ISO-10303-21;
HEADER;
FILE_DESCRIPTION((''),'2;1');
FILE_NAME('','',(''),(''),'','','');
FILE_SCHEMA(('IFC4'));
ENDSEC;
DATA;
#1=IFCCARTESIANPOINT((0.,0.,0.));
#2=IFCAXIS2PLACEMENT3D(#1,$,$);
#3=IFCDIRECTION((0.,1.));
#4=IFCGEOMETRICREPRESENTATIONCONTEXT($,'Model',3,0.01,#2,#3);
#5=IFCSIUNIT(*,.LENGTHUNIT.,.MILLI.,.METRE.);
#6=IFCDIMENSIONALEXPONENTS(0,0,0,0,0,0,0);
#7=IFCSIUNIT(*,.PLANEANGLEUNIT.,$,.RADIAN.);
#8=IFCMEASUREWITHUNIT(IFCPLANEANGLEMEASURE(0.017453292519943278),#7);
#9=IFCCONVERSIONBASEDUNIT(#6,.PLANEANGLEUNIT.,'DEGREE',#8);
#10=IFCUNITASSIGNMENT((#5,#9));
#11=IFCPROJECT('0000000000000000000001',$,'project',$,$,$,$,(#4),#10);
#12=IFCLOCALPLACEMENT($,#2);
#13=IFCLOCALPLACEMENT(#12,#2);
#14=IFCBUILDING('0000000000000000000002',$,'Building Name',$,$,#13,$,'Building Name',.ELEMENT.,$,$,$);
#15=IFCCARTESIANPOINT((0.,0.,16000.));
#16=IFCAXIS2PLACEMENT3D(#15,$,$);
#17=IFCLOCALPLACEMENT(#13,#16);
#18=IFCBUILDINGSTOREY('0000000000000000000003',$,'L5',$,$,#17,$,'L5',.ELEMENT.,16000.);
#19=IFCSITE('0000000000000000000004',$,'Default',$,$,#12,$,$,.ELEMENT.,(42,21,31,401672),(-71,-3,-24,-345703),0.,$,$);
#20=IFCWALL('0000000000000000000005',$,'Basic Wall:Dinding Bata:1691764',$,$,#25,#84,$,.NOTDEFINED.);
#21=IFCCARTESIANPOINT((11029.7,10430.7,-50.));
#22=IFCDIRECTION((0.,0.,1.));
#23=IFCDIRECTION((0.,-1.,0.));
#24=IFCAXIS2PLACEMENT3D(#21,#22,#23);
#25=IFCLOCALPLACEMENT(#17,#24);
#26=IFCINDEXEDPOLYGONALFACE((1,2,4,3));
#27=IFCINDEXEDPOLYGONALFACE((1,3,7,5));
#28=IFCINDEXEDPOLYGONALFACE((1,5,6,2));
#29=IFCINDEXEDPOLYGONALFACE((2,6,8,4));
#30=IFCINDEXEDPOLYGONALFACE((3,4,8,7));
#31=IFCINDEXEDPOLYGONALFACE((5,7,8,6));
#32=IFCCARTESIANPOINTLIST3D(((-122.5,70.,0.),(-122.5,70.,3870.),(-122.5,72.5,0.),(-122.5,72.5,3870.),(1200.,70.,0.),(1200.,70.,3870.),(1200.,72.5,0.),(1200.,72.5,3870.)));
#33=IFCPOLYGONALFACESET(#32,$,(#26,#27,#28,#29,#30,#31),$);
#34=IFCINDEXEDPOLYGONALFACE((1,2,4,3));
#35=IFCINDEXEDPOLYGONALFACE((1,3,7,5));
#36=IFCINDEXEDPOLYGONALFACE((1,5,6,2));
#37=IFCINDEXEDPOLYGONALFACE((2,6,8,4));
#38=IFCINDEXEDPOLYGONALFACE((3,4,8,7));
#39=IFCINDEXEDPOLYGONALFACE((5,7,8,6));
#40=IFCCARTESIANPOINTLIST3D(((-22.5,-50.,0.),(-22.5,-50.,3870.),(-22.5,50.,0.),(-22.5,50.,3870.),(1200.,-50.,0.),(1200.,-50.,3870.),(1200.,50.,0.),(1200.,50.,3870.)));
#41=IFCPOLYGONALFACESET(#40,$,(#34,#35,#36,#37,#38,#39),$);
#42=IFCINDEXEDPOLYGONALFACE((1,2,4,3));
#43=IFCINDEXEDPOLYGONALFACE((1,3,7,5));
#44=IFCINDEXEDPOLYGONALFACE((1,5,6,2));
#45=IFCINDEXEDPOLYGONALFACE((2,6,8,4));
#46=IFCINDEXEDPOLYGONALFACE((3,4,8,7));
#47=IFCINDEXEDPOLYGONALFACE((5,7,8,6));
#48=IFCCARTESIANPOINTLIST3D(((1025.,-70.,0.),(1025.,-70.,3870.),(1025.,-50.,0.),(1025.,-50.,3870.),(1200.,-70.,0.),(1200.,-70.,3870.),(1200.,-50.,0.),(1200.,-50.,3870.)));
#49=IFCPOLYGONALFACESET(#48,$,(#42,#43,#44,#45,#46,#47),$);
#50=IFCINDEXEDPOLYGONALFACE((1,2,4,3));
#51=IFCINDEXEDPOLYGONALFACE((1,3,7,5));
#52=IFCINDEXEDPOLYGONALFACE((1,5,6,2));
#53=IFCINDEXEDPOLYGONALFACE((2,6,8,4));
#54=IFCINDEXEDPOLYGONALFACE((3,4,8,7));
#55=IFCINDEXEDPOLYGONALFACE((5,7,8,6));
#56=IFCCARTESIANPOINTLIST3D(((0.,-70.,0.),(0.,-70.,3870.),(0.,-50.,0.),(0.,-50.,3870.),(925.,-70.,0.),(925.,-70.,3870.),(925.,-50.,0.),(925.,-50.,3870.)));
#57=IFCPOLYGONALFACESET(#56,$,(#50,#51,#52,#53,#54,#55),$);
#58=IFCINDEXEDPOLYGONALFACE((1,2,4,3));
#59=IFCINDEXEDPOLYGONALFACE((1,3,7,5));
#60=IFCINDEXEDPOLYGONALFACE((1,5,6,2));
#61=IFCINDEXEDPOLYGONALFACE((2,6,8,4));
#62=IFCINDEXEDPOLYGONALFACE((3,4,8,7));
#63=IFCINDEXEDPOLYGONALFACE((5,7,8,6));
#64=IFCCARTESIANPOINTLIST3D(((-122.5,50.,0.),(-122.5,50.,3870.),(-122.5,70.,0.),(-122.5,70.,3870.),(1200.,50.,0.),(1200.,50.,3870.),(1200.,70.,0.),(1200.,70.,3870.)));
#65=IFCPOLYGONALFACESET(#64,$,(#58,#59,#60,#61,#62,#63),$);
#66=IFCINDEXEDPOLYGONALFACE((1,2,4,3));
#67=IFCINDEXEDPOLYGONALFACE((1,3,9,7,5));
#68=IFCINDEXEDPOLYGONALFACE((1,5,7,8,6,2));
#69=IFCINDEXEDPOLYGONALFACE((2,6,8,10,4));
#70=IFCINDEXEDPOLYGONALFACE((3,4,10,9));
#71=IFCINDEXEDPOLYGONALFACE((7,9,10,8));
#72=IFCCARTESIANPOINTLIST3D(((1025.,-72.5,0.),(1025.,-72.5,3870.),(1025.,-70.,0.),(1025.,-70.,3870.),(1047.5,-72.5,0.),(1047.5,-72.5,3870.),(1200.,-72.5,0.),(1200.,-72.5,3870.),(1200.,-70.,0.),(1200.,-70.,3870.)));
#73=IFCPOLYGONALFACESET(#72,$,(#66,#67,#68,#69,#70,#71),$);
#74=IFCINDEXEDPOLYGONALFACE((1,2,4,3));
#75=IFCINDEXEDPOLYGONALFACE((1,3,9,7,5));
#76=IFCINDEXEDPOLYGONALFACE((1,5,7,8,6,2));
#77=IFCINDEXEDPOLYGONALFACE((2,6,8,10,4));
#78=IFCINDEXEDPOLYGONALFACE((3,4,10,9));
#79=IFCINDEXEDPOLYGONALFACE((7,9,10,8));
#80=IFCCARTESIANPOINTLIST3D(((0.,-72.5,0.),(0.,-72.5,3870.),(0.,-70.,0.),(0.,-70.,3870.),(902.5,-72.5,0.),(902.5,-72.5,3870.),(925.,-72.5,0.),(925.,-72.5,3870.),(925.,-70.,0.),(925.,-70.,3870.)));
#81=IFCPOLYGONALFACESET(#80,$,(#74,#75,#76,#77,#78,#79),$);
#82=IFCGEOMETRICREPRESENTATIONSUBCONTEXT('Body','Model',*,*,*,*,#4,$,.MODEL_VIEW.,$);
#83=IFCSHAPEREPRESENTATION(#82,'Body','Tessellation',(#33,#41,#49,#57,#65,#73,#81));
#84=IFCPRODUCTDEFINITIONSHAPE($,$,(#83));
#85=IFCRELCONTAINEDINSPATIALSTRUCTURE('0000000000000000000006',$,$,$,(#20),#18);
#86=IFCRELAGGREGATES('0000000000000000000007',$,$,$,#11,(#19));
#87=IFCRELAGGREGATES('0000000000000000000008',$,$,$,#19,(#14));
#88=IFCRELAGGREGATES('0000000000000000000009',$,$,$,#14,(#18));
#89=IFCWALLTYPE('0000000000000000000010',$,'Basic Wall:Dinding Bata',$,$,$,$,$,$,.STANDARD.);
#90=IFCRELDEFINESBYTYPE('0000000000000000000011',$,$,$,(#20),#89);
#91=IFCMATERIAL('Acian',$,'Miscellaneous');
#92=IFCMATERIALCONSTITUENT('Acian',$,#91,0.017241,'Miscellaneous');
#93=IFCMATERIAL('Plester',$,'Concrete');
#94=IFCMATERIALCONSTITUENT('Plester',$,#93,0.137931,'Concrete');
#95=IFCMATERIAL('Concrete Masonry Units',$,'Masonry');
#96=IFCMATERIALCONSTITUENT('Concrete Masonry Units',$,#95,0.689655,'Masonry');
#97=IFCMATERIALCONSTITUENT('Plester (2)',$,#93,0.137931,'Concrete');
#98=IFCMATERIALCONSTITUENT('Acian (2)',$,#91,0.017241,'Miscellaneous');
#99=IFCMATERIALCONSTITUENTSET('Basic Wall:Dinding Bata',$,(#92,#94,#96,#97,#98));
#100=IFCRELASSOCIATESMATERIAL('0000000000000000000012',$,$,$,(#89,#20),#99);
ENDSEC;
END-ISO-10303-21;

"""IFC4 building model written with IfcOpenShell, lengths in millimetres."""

from ifc_helpers import new_model, entity, si_unit, converted_unit, direction, frame, origin, place, context, subcontext, project, spatial, indexed_curve, outline, extrude, material, constituent, constituent_set, type_object, element, save


model = new_model("IFC4")

# Units and contexts
model_context = context("Model", 3, precision=0.01, world=origin(), true_north=direction((0.0, 1.0)))
body_context = subcontext(model_context, "Body", "Model", "MODEL_VIEW")
ifc_project = project(units=[si_unit("LENGTHUNIT", "METRE", prefix="MILLI"), converted_unit("PLANEANGLEUNIT", "DEGREE", entity("IfcPlaneAngleMeasure", 0.017453292519943278), si_unit("PLANEANGLEUNIT", "RADIAN"), dimensions=[0, 0, 0, 0, 0, 0, 0])], contexts=[model_context])

# Site, building, storey
site_placement = place(None, origin())
site = spatial("IfcSite", under=ifc_project, at=site_placement, Name="Default", CompositionType="ELEMENT", RefLatitude=(42, 21, 31, 401672), RefLongitude=(-71, -3, -24, -345703), RefElevation=0.0)
building_placement = place(site_placement, origin())
building = spatial("IfcBuilding", under=site, at=building_placement, Name="Building Name", LongName="Building Name", CompositionType="ELEMENT")
storey_placement = place(building_placement, frame((0.0, 0.0, 16000.0)))
storey = spatial("IfcBuildingStorey", under=building, at=storey_placement, Name="L5", LongName="L5", CompositionType="ELEMENT", Elevation=16000.0)

# Wall
ifc_material_1 = material(Name="Acian", Category="Miscellaneous")
ifc_constituent_1 = constituent(ifc_material_1, Name="Acian", Category="Miscellaneous", fraction=0.017241)
ifc_material_2 = material(Name="Plester", Category="Concrete")
ifc_constituent_2 = constituent(ifc_material_2, Name="Plester", Category="Concrete", fraction=0.137931)
ifc_material_3 = material(Name="Concrete Masonry Units", Category="Masonry")
ifc_constituent_3 = constituent(ifc_material_3, Name="Concrete Masonry Units", Category="Masonry", fraction=0.689655)
ifc_constituent_4 = constituent(ifc_material_2, Name="Plester (2)", Category="Concrete", fraction=0.137931)
ifc_constituent_5 = constituent(ifc_material_1, Name="Acian (2)", Category="Miscellaneous", fraction=0.017241)
ifc_constituent_set = constituent_set(constituents=[ifc_constituent_1, ifc_constituent_2, ifc_constituent_3, ifc_constituent_4, ifc_constituent_5], Name="Basic Wall:Dinding Bata")
wall_type = type_object("IfcWallType", Name="Basic Wall:Dinding Bata", PredefinedType="STANDARD", material=ifc_constituent_set)
wall_1_placement = place(storey_placement, frame((11029.7, 10430.7, -50.0), z_axis=(0.0, 0.0, 1.0), x_axis=(0.0, -1.0, 0.0)))
element("IfcWall", 1, at=wall_1_placement, inside=storey, type_object=wall_type, material=ifc_constituent_set, Name="Basic Wall:Dinding Bata:1691764", PredefinedType="NOTDEFINED", context=body_context, shape_type="SweptSolid", body=[
    extrude(outline(indexed_curve([(-1.3, -661.2), (1.2, -661.2), (1.3, 661.2), (-1.2, 661.2), (-1.3, -661.2)], self_intersect=False)), frame((538.7, 71.2, 0.0), z_axis=(0.0, 0.0, 1.0), x_axis=(0.0, -1.0, 0.0)), (0.0, 0.0, 1.0), 3870.0),
    extrude(outline(indexed_curve([(-611.2, -50.0), (611.2, -50.0), (611.2, 50.0), (-611.2, 50.0), (-611.2, -50.0)], self_intersect=False)), frame((588.7, 0.0, 0.0)), (0.0, 0.0, 1.0), 3870.0),
    extrude(outline(indexed_curve([(-87.5, -10.0), (87.5, -10.0), (87.5, 10.0), (-87.5, 10.0), (-87.5, -10.0)], self_intersect=False)), frame((1112.5, -60.0, 0.0), z_axis=(0.0, 0.0, 1.0), x_axis=(-1.0, 0.0, 0.0)), (0.0, 0.0, 1.0), 3870.0),
    extrude(outline(indexed_curve([(-462.5, -10.0), (462.5, -10.0), (462.5, 10.0), (-462.5, 10.0), (-462.5, -10.0)], self_intersect=False)), frame((462.5, -60.0, 0.0)), (0.0, 0.0, 1.0), 3870.0),
    extrude(outline(indexed_curve([(-661.2, -10.0), (661.2, -10.0), (661.2, 10.0), (-661.2, 10.0), (-661.2, -10.0)], self_intersect=False)), frame((538.7, 60.0, 0.0)), (0.0, 0.0, 1.0), 3870.0),
    extrude(outline(indexed_curve([(-1.0, -100.5), (1.5, -100.5), (1.5, 74.5), (-1.0, 74.5), (-1.0, 52.0), (-1.0, -100.5)], self_intersect=False)), frame((1099.5, -71.5, 0.0), z_axis=(0.0, 0.0, 1.0), x_axis=(0.0, 1.0, 0.0)), (0.0, 0.0, 1.0), 3870.0),
    extrude(outline(indexed_curve([(352.0, -1.0), (374.5, -1.0), (374.5, 1.5), (-550.5, 1.5), (-550.5, -1.0), (352.0, -1.0)], self_intersect=False)), frame((550.5, -71.5, 0.0)), (0.0, 0.0, 1.0), 3870.0),
])

save(model, "model.ifc")
